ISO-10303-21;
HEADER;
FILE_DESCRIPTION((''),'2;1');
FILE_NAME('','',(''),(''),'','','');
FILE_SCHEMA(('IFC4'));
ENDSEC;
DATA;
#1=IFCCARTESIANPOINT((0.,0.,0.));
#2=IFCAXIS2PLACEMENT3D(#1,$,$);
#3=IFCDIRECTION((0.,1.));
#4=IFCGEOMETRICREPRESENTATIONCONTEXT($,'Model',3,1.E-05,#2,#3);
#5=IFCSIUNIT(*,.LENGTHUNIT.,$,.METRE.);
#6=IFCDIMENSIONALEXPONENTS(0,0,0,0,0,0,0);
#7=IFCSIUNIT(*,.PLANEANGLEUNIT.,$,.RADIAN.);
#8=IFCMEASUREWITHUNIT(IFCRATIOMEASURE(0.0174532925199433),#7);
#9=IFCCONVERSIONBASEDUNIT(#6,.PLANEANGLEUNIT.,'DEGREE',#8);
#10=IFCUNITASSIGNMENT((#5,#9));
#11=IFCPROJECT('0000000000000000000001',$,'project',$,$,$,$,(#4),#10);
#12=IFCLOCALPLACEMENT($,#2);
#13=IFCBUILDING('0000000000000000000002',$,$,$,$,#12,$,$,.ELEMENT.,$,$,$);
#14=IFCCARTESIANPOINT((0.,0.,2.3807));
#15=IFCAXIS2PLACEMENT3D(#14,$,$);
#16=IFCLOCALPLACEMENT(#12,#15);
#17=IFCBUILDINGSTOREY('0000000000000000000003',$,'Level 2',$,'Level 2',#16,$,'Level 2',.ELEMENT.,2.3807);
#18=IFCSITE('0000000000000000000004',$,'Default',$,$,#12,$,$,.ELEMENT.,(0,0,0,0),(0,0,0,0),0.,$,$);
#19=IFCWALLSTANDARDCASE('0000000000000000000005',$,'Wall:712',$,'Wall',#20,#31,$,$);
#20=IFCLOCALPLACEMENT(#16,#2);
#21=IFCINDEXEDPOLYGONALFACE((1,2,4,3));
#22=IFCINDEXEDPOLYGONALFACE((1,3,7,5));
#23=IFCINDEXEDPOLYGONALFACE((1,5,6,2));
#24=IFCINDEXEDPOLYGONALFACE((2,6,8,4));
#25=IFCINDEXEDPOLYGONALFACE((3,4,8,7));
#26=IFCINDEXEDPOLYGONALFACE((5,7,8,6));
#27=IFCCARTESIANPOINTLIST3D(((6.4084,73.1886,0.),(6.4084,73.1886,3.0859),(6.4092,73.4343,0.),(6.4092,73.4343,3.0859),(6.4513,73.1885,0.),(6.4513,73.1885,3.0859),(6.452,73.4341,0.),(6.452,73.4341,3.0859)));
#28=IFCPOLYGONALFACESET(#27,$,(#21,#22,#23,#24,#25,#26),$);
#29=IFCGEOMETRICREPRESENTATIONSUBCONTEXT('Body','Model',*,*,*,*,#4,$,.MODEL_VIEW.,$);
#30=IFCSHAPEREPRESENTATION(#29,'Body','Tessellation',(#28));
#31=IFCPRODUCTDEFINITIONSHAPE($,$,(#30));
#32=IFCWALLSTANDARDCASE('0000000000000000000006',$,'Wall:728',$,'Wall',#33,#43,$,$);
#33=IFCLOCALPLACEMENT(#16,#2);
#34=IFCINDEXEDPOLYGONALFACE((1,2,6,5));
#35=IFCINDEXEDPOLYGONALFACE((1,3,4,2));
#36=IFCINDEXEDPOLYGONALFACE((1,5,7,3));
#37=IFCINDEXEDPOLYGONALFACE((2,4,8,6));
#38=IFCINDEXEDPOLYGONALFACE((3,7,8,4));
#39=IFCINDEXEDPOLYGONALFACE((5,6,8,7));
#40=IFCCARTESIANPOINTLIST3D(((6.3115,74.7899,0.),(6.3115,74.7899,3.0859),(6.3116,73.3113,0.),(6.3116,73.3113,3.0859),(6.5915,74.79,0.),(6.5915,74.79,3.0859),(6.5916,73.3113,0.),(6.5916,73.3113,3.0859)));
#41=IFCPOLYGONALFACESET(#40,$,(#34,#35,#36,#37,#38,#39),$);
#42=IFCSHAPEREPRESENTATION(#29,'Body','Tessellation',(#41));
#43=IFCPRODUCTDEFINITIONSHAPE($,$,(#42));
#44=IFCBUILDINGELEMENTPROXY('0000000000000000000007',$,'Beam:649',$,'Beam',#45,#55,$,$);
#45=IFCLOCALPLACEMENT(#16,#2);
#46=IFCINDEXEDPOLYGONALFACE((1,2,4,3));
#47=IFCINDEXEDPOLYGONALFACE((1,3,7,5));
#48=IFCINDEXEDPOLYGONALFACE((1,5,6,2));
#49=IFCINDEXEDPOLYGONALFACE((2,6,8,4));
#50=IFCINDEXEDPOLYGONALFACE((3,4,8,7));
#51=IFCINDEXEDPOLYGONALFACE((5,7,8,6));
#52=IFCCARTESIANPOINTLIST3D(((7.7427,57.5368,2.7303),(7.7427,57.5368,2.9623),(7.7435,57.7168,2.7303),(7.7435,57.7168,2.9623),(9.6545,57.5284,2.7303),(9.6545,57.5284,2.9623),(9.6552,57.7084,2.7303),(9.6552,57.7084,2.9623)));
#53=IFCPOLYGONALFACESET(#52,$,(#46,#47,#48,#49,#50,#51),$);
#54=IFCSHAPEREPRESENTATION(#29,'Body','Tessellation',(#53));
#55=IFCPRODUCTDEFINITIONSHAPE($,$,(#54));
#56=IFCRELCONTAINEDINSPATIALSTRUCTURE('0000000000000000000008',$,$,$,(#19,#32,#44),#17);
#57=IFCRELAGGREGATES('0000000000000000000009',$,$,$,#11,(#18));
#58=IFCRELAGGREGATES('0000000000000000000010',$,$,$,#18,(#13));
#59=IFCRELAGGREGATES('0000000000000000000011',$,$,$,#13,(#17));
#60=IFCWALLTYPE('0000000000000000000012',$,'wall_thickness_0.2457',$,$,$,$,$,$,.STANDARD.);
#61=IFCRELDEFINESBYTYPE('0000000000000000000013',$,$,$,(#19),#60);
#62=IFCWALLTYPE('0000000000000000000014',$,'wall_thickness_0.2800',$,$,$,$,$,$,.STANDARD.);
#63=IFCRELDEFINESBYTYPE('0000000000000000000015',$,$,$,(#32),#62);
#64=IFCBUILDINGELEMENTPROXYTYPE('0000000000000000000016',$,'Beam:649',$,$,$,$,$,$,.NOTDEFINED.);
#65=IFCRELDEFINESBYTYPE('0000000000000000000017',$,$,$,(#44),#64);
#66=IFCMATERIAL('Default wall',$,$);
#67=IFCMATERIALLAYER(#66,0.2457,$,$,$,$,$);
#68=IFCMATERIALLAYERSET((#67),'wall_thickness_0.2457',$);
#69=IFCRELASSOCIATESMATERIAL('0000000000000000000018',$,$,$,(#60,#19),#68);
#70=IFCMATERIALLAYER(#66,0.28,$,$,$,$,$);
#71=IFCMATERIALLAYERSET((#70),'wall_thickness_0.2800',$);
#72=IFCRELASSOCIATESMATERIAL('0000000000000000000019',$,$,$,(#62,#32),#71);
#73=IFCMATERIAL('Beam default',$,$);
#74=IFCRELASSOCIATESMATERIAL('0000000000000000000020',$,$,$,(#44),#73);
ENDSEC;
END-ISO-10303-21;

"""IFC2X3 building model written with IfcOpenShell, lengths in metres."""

from ifc_helpers import new_model, entity, si_unit, converted_unit, direction, frame, origin, place, context, subcontext, project, spatial, polyline, outline, extrude, source, transform, mapped, material, layer, layer_set, layer_usage, type_object, type_shapes, element, save


model = new_model("IFC2X3")

# Units and contexts
model_context = context("Model", 3, precision=1e-05, world=origin(), true_north=direction((0.0, 1.0)))
body_context = subcontext(model_context, "Body", "Model", "MODEL_VIEW")
ifc_project = project(units=[si_unit("LENGTHUNIT", "METRE"), converted_unit("PLANEANGLEUNIT", "DEGREE", entity("IfcRatioMeasure", 0.0174532925199433), si_unit("PLANEANGLEUNIT", "RADIAN"), dimensions=[0, 0, 0, 0, 0, 0, 0])], contexts=[model_context])

# Site, building, storey
placement_1 = place(None, origin())
site = spatial("IfcSite", under=ifc_project, at=placement_1, Name="Default", CompositionType="ELEMENT", RefLatitude=(0, 0, 0, 0), RefLongitude=(0, 0, 0, 0), RefElevation=0.0)
building = spatial("IfcBuilding", under=site, at=placement_1, CompositionType="ELEMENT")
storey_placement = place(placement_1, frame((0.0, 0.0, 2.3807)))
storey = spatial("IfcBuildingStorey", under=building, at=storey_placement, Name="Level 2", ObjectType="Level 2", LongName="Level 2", CompositionType="ELEMENT", Elevation=2.3807)

# Shared definitions
ifc_material_1 = material(Name="Default wall")

# Walls
ifc_layer_1 = layer(ifc_material_1, 0.2457)
ifc_layer_set_1 = layer_set([ifc_layer_1], Name="wall_thickness_0.2457")
ifc_layer_usage_1 = layer_usage(ifc_layer_set_1, "AXIS2", "POSITIVE", -0.1228)
wall_type_1 = type_object("IfcWallType", Name="wall_thickness_0.2457", PredefinedType="STANDARD", material=ifc_layer_set_1)
wall_1_placement = place(storey_placement, frame((6.4088, 73.3114, 0.0), z_axis=(0.0, 0.0, 1.0), x_axis=(0.999995, -0.003027, 0.0)))
element("IfcWallStandardCase", 1, at=wall_1_placement, inside=storey, type_object=wall_type_1, material=ifc_layer_usage_1, Name="Wall:712", ObjectType="Wall", context=body_context, shape_type="SweptSolid", body=[
    extrude(outline(polyline([(0.0428, -0.1228), (0.0428, 0.1228), (0.0, 0.1228), (0.0, -0.1228), (0.0428, -0.1228)])), origin(), (0.0, 0.0, 1.0), 3.0859),
])
ifc_layer_2 = layer(ifc_material_1, 0.28)
ifc_layer_set_2 = layer_set([ifc_layer_2], Name="wall_thickness_0.2800")
ifc_layer_usage_2 = layer_usage(ifc_layer_set_2, "AXIS2", "POSITIVE", -0.14)
wall_type_2 = type_object("IfcWallType", Name="wall_thickness_0.2800", PredefinedType="STANDARD", material=ifc_layer_set_2)
wall_2_placement = place(storey_placement, frame((6.4515, 74.79, 0.0), z_axis=(0.0, 0.0, 1.0), x_axis=(0.000091, -1.0, 0.0)))
element("IfcWallStandardCase", 2, at=wall_2_placement, inside=storey, type_object=wall_type_2, material=ifc_layer_usage_2, Name="Wall:728", ObjectType="Wall", context=body_context, shape_type="SweptSolid", body=[
    extrude(outline(polyline([(1.4787, -0.14), (1.4787, 0.14), (0.0, 0.14), (0.0, -0.14), (1.4787, -0.14)])), origin(), (0.0, 0.0, 1.0), 3.0859),
])

# Building element proxy
ifc_material_2 = material(Name="Beam default")
building_element_proxy_type = type_object("IfcBuildingElementProxyType", Name="Beam:649", PredefinedType="NOTDEFINED")
shared_shape_1 = source(origin(), body_context, "Body", "SweptSolid", [
    extrude(outline(polyline([(1.9118, -0.09), (1.9118, 0.09), (0.0, 0.09), (0.0, -0.09), (1.9118, -0.09)])), origin(), (0.0, 0.0, 1.0), 0.232),
])
type_shapes(building_element_proxy_type, [shared_shape_1])
placement_2 = place(placement_1, frame((0.0, 0.0, 5.111)))
proxy_placement = place(placement_2, frame((7.7431, 57.6268, 0.0), z_axis=(0.0, 0.0, 1.0), x_axis=(0.99999, -0.004402, 0.0)))
element("IfcBuildingElementProxy", 3, at=proxy_placement, inside=storey, type_object=building_element_proxy_type, material=ifc_material_2, Name="Beam:649", ObjectType="Beam", context=body_context, shape_type="MappedRepresentation", body=[
    mapped(shared_shape_1, transform((0.0, 0.0, 0.0), scale=1.0)),
])

save(model, "model.ifc")
